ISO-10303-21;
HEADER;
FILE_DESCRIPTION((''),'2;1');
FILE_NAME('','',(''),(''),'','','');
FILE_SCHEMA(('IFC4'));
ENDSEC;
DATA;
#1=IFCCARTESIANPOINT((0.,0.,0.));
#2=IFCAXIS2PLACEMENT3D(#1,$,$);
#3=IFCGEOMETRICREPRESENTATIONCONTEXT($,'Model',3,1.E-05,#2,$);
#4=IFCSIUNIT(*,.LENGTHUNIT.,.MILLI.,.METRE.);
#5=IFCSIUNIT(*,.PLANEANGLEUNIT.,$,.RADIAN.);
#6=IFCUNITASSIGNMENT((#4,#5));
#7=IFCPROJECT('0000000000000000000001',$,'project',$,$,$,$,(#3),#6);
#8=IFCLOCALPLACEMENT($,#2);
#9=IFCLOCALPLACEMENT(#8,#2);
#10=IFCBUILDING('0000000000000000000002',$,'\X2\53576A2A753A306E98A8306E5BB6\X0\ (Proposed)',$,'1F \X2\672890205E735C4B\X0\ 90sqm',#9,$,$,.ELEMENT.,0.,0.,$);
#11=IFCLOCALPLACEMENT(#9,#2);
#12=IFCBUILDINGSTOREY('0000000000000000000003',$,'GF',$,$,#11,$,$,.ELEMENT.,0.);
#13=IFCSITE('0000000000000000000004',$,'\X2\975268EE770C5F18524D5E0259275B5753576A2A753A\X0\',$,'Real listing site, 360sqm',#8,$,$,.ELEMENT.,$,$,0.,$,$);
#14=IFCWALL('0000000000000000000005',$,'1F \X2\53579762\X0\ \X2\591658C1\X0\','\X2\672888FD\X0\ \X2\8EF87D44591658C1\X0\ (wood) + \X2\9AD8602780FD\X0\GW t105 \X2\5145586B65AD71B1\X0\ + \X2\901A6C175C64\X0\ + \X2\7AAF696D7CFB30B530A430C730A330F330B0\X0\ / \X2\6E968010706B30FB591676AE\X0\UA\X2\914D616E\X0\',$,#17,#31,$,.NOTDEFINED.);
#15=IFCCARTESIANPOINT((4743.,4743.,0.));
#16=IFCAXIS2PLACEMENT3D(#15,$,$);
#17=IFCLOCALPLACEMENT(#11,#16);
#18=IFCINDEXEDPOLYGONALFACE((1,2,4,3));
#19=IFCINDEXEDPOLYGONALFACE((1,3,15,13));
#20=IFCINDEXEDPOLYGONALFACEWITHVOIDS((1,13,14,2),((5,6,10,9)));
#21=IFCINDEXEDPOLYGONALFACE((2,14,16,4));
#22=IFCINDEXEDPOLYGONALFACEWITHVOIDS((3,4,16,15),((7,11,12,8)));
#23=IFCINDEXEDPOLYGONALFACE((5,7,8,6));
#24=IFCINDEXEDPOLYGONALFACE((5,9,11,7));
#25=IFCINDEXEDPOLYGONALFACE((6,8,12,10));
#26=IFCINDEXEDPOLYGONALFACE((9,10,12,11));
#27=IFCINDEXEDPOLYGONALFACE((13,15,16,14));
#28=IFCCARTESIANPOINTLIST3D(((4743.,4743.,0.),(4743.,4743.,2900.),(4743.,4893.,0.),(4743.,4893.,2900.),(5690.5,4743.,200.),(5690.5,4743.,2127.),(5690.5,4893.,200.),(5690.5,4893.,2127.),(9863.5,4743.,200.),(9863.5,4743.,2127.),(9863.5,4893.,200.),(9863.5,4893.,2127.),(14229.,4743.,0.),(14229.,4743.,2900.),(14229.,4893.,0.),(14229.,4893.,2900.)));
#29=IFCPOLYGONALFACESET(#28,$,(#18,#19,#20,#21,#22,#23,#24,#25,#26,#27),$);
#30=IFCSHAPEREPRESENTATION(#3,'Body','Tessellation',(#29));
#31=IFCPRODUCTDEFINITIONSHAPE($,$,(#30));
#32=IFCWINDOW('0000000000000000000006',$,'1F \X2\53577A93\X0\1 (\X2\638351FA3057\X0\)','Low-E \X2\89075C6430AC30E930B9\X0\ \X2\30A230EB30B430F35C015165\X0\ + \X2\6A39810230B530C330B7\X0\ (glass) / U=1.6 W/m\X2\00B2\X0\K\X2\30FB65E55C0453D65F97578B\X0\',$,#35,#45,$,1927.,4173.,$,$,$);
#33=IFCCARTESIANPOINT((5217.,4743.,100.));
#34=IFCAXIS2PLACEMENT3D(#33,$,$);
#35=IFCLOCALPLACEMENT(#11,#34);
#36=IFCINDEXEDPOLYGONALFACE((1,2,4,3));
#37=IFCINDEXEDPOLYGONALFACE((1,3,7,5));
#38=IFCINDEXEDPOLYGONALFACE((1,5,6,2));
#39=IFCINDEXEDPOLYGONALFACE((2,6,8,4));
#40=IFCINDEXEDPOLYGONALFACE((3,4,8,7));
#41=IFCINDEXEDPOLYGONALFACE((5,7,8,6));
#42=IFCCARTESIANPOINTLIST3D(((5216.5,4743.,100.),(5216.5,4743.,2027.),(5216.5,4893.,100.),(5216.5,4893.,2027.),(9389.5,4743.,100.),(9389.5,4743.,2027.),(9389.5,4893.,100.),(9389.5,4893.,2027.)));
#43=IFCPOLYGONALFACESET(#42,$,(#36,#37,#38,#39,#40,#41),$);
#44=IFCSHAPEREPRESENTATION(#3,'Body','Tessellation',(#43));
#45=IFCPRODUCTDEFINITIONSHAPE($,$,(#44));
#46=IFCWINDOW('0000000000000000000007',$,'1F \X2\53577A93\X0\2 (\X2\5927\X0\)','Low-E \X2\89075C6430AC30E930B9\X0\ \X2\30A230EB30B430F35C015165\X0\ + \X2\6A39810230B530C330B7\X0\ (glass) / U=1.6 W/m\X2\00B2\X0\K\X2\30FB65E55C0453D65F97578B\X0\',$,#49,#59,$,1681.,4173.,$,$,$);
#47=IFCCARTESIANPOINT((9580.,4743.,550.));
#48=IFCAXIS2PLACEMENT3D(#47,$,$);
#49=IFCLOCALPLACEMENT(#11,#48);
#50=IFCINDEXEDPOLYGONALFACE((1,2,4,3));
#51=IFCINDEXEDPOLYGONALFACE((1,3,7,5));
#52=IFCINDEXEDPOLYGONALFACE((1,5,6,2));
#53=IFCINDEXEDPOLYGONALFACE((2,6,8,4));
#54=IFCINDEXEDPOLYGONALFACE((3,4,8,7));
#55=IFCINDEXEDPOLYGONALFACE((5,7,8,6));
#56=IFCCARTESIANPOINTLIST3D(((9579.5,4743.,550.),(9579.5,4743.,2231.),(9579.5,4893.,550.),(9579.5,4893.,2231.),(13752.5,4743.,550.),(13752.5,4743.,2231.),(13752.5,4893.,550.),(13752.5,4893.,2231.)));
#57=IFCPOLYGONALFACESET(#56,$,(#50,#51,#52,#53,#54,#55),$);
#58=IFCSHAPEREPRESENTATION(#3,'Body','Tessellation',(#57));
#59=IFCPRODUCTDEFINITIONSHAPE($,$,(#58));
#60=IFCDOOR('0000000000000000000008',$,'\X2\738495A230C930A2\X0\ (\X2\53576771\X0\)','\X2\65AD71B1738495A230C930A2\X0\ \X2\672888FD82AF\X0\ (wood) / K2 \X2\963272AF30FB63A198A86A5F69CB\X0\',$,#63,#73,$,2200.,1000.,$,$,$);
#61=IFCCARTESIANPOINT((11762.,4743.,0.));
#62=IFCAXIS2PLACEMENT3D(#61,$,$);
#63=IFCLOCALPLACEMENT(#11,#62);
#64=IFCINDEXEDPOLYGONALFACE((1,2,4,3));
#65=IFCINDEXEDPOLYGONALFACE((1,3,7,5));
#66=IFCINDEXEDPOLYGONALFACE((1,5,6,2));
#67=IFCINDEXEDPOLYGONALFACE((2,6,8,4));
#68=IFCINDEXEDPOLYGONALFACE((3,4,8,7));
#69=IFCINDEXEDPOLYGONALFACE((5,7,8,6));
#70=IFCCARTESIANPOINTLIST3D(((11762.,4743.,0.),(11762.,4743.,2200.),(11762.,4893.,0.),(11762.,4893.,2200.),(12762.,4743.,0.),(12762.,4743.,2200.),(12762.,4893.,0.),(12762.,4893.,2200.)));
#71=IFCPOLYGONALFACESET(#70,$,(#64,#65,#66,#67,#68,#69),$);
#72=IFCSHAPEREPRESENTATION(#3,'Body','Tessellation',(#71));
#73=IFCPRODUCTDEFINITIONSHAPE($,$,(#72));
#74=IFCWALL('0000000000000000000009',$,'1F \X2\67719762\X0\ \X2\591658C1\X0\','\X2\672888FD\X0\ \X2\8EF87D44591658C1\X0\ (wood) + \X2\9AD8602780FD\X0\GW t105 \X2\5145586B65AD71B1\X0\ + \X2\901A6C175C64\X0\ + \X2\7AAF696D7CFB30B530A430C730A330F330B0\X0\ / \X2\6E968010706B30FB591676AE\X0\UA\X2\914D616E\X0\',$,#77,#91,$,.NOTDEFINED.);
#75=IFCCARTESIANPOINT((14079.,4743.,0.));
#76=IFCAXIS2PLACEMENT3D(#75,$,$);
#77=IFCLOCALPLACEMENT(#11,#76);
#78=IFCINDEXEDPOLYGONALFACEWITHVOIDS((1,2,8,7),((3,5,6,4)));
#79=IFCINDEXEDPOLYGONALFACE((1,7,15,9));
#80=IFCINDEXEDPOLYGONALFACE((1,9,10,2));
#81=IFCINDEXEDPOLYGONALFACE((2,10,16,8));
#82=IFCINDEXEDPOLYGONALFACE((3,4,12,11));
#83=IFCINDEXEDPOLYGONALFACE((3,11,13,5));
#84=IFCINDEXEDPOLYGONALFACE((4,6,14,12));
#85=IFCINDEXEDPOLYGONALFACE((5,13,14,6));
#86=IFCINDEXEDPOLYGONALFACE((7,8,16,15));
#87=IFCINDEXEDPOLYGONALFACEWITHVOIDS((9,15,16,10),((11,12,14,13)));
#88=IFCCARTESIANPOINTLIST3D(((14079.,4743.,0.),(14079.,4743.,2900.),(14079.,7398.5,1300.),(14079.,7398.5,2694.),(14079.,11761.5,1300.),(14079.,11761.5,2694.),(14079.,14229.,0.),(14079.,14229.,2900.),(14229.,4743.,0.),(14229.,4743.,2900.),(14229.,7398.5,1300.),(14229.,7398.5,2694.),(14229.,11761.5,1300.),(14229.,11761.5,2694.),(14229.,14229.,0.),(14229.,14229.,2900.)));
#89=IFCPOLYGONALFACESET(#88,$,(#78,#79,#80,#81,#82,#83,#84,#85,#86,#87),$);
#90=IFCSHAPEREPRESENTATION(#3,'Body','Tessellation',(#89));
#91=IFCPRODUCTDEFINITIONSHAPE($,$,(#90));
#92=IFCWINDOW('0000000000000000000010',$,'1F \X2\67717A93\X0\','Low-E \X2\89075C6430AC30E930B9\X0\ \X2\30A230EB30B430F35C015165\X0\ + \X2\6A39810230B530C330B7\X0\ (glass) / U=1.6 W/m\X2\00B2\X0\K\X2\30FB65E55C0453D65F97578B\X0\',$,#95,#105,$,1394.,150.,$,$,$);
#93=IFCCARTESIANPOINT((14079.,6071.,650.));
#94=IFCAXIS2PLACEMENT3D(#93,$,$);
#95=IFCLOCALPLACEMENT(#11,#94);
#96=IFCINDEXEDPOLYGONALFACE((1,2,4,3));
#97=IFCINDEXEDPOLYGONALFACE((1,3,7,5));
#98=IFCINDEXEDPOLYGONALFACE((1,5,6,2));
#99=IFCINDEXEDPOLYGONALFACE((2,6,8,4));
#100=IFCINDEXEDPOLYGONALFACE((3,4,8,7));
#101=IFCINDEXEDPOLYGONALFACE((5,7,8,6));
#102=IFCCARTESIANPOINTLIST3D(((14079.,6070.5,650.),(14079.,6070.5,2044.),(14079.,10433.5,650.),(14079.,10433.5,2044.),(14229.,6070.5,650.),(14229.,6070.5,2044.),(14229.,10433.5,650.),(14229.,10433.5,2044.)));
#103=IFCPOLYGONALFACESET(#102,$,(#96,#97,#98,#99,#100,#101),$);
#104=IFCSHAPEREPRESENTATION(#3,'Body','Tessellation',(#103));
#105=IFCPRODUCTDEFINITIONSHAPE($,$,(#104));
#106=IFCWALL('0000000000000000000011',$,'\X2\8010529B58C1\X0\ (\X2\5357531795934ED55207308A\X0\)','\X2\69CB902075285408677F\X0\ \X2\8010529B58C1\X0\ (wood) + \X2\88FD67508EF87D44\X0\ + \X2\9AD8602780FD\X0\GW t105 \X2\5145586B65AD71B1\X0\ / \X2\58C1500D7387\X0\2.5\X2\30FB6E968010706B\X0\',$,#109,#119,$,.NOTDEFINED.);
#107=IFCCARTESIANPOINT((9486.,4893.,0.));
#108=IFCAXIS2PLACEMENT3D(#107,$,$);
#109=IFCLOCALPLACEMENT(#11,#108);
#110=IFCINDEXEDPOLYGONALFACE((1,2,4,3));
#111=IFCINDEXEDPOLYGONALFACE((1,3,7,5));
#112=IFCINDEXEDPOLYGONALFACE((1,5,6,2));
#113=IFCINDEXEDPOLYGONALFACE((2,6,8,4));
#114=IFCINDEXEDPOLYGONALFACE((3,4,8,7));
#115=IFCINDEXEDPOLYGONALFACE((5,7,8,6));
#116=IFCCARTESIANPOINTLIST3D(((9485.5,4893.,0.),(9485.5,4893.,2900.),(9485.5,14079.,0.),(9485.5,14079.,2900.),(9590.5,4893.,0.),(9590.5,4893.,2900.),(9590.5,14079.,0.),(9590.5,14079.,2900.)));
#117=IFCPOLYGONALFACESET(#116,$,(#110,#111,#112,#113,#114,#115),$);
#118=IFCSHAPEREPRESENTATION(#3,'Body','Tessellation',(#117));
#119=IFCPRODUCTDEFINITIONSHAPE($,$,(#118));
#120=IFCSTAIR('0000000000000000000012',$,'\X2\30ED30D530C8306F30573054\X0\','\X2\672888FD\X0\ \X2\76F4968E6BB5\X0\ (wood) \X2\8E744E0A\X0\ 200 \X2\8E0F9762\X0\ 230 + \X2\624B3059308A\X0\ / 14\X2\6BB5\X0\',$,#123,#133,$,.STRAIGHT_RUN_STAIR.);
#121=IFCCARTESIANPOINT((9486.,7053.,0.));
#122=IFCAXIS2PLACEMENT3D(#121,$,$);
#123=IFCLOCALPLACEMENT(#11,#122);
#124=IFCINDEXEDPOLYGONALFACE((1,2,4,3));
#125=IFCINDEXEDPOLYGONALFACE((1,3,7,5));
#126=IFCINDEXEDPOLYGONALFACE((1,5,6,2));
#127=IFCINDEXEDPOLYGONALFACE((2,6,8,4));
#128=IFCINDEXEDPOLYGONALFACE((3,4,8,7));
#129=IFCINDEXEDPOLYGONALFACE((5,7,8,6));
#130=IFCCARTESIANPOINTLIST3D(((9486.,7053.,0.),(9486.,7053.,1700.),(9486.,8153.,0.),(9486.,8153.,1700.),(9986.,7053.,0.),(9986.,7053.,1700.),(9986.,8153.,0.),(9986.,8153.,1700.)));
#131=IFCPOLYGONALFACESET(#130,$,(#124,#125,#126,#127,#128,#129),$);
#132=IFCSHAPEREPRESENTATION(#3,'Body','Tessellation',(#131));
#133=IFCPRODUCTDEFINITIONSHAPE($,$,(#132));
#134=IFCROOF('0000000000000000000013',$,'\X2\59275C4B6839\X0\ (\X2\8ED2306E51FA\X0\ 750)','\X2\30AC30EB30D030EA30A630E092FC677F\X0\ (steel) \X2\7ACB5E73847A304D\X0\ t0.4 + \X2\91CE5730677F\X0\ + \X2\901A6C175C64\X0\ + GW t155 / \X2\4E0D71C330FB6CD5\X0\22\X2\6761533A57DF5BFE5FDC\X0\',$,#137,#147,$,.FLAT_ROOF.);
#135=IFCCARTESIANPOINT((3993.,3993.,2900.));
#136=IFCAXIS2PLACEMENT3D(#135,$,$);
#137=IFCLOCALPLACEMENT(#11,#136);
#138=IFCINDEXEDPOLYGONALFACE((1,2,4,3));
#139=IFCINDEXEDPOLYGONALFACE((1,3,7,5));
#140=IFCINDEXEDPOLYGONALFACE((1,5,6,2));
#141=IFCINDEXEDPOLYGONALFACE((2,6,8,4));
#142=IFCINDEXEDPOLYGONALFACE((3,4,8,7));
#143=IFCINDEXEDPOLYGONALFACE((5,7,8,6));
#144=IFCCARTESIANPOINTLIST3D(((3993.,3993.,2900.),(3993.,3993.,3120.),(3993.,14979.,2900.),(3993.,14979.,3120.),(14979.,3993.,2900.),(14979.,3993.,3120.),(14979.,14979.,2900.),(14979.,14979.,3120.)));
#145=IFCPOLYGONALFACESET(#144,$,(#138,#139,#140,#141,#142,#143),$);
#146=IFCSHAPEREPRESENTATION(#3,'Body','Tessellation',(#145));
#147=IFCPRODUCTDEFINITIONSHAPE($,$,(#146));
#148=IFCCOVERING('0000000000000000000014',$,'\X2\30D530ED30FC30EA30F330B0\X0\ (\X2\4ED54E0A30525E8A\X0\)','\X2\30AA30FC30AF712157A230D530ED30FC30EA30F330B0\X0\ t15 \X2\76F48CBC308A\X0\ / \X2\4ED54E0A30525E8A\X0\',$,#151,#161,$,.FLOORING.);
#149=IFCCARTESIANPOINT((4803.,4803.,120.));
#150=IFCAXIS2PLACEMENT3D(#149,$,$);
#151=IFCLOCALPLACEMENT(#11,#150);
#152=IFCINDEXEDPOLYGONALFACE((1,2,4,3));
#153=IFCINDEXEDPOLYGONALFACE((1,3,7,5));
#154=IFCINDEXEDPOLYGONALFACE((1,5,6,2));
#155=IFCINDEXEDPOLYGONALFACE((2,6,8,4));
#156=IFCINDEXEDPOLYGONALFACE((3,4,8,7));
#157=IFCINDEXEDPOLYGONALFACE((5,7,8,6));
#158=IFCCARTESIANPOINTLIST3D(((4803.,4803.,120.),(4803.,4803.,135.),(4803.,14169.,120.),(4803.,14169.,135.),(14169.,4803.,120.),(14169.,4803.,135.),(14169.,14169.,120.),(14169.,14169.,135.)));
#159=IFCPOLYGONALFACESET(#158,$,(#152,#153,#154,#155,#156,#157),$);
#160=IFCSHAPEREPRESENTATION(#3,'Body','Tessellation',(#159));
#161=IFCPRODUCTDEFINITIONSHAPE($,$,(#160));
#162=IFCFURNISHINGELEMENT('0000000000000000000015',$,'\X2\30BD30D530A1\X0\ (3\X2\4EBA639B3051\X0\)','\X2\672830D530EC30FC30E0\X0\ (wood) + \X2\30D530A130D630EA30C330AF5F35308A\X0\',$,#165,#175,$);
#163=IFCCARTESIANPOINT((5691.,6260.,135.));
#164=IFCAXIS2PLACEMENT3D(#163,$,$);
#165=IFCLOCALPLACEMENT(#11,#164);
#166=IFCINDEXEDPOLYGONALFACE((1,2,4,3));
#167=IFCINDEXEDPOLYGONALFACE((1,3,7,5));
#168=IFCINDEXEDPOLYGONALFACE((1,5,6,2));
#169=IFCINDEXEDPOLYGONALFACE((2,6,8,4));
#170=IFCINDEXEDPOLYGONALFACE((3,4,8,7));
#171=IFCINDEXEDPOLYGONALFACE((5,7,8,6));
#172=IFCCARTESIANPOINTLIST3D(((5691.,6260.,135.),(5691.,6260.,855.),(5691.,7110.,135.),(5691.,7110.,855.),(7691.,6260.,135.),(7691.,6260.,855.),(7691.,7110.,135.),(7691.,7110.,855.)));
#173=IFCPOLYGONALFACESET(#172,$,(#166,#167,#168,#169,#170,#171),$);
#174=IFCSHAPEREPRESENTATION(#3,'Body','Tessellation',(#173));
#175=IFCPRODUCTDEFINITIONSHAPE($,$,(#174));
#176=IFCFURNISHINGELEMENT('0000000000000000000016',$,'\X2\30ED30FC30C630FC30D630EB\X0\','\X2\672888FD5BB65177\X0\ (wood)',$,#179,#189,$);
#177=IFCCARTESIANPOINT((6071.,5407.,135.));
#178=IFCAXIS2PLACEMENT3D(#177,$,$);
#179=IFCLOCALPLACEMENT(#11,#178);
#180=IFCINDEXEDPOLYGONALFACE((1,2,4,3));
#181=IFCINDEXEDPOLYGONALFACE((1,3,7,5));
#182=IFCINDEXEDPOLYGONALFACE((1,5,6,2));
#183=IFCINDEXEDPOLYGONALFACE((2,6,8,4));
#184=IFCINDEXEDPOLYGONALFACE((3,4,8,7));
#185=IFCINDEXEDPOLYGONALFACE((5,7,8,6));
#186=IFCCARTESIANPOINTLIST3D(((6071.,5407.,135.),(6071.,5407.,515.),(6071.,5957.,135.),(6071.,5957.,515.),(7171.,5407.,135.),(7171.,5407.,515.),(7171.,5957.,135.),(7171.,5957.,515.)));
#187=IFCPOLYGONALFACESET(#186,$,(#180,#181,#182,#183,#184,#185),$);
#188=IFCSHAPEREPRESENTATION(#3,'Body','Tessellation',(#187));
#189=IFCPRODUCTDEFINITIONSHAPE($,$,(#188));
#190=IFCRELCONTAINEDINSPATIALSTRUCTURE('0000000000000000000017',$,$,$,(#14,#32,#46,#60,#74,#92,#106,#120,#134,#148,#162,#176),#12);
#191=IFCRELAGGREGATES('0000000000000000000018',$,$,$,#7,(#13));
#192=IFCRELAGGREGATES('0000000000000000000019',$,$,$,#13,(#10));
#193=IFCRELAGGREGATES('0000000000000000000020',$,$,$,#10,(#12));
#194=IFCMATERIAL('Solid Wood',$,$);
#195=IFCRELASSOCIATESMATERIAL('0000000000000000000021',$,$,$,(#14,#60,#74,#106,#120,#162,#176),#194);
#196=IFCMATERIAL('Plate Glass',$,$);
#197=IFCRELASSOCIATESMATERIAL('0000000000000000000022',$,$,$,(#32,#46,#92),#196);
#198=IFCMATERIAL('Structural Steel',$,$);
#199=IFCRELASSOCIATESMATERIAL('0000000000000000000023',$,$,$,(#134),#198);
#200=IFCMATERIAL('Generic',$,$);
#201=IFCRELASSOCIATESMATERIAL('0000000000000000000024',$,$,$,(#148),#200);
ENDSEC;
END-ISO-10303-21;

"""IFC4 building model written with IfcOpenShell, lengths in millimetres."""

from ifc_helpers import new_model, si_unit, frame, frame_2d, origin, place, context, project, spatial, rectangle, extrude, material, element, fill, save


model = new_model("IFC4")

# Units and contexts
model_context = context("Model", 3, precision=1e-05, world=origin())
ifc_project = project(units=[si_unit("LENGTHUNIT", "METRE", prefix="MILLI"), si_unit("PLANEANGLEUNIT", "RADIAN")], contexts=[model_context])

# Site, building, storey
site_placement = place(None, origin())
site = spatial("IfcSite", under=ifc_project, at=site_placement, Name="青森県弘前市大字南横町", ObjectType="Real listing site, 360sqm", CompositionType="ELEMENT", RefElevation=0.0)
building_placement = place(site_placement, origin())
building = spatial("IfcBuilding", under=site, at=building_placement, Name="南横町の風の家 (Proposed)", ObjectType="1F 木造平屋 90sqm", CompositionType="ELEMENT", ElevationOfRefHeight=0.0, ElevationOfTerrain=0.0)
storey_placement = place(building_placement, origin())
storey = spatial("IfcBuildingStorey", under=building, at=storey_placement, Name="GF", CompositionType="ELEMENT", Elevation=0.0)

# Shared definitions
ifc_material_1 = material(Name="Solid Wood")

# Wall, openings, windows, door
wall_1_placement = place(storey_placement, frame((4743.0, 4743.0, 0.0)))
wall_1 = element("IfcWall", 1, at=wall_1_placement, inside=storey, material=ifc_material_1, Name="1F 南面 外壁", Description="木製 軸組外壁 (wood) + 高性能GW t105 充填断熱 + 通気層 + 窯業系サイディング / 準耐火・外皮UA配慮", PredefinedType="NOTDEFINED", context=model_context, shape_type="SweptSolid", body=[
    extrude(rectangle(XDim=9486.0, YDim=150.0, at=frame_2d((4743.0, 75.0))), frame((4743.0, 4743.0, 0.0)), (0.0, 0.0, 1.0), 2900.0),
])
opening_1_placement = place(storey_placement, frame((5217.0, 4743.0, 100.0)))
opening_1 = element("IfcOpeningElement", 2, at=opening_1_placement, cuts=wall_1, PredefinedType="NOTDEFINED", context=model_context, shape_type="SweptSolid", body=[
    extrude(rectangle(XDim=4173.0, YDim=150.0, at=frame_2d((2086.0, 75.0))), frame((5217.0, 4743.0, 100.0)), (0.0, 0.0, 1.0), 1927.0),
])
opening_2_placement = place(storey_placement, frame((9580.0, 4743.0, 550.0)))
opening_2 = element("IfcOpeningElement", 3, at=opening_2_placement, cuts=wall_1, PredefinedType="NOTDEFINED", context=model_context, shape_type="SweptSolid", body=[
    extrude(rectangle(XDim=4173.0, YDim=150.0, at=frame_2d((2086.0, 75.0))), frame((9580.0, 4743.0, 550.0)), (0.0, 0.0, 1.0), 1681.0),
])
opening_3_placement = place(storey_placement, frame((11762.0, 4743.0, 0.0)))
opening_3 = element("IfcOpeningElement", 4, at=opening_3_placement, cuts=wall_1, PredefinedType="NOTDEFINED", context=model_context, shape_type="SweptSolid", body=[
    extrude(rectangle(XDim=1000.0, YDim=150.0, at=frame_2d((500.0, 75.0))), frame((11762.0, 4743.0, 0.0)), (0.0, 0.0, 1.0), 2200.0),
])
ifc_material_2 = material(Name="Plate Glass")
window_1_placement = place(storey_placement, frame((5217.0, 4743.0, 100.0)))
window_1 = element("IfcWindow", 5, at=window_1_placement, inside=storey, material=ifc_material_2, Name="1F 南窓1 (掃出し)", Description="Low-E 複層ガラス アルゴン封入 + 樹脂サッシ (glass) / U=1.6 W/m²K・日射取得型", OverallHeight=1927.0, OverallWidth=4173.0, context=model_context, shape_type="SweptSolid", body=[
    extrude(rectangle(XDim=4173.0, YDim=150.0, at=frame_2d((2086.0, 75.0))), frame((5217.0, 4743.0, 100.0)), (0.0, 0.0, 1.0), 1927.0),
])
fill(opening_1, window_1)
window_2_placement = place(storey_placement, frame((9580.0, 4743.0, 550.0)))
window_2 = element("IfcWindow", 6, at=window_2_placement, inside=storey, material=ifc_material_2, Name="1F 南窓2 (大)", Description="Low-E 複層ガラス アルゴン封入 + 樹脂サッシ (glass) / U=1.6 W/m²K・日射取得型", OverallHeight=1681.0, OverallWidth=4173.0, context=model_context, shape_type="SweptSolid", body=[
    extrude(rectangle(XDim=4173.0, YDim=150.0, at=frame_2d((2086.0, 75.0))), frame((9580.0, 4743.0, 550.0)), (0.0, 0.0, 1.0), 1681.0),
])
fill(opening_2, window_2)
door_placement = place(storey_placement, frame((11762.0, 4743.0, 0.0)))
door = element("IfcDoor", 7, at=door_placement, inside=storey, material=ifc_material_1, Name="玄関ドア (南東)", Description="断熱玄関ドア 木製芯 (wood) / K2 防犯・採風機構", OverallHeight=2200.0, OverallWidth=1000.0, context=model_context, shape_type="SweptSolid", body=[
    extrude(rectangle(XDim=1000.0, YDim=150.0, at=frame_2d((500.0, 75.0))), frame((11762.0, 4743.0, 0.0)), (0.0, 0.0, 1.0), 2200.0),
])
fill(opening_3, door)

# Wall, opening, window
wall_2_placement = place(storey_placement, frame((14079.0, 4743.0, 0.0)))
wall_2 = element("IfcWall", 8, at=wall_2_placement, inside=storey, material=ifc_material_1, Name="1F 東面 外壁", Description="木製 軸組外壁 (wood) + 高性能GW t105 充填断熱 + 通気層 + 窯業系サイディング / 準耐火・外皮UA配慮", PredefinedType="NOTDEFINED", context=model_context, shape_type="SweptSolid", body=[
    extrude(rectangle(XDim=150.0, YDim=9486.0, at=frame_2d((75.0, 4743.0))), frame((14079.0, 4743.0, 0.0)), (0.0, 0.0, 1.0), 2900.0),
])
opening_4_placement = place(storey_placement, frame((14079.0, 6071.0, 650.0)))
opening_4 = element("IfcOpeningElement", 9, at=opening_4_placement, cuts=wall_2, PredefinedType="NOTDEFINED", context=model_context, shape_type="SweptSolid", body=[
    extrude(rectangle(XDim=150.0, YDim=4363.0, at=frame_2d((75.0, 2181.0))), frame((14079.0, 6071.0, 650.0)), (0.0, 0.0, 1.0), 1394.0),
])
window_3_placement = place(storey_placement, frame((14079.0, 6071.0, 650.0)))
window_3 = element("IfcWindow", 10, at=window_3_placement, inside=storey, material=ifc_material_2, Name="1F 東窓", Description="Low-E 複層ガラス アルゴン封入 + 樹脂サッシ (glass) / U=1.6 W/m²K・日射取得型", OverallHeight=1394.0, OverallWidth=150.0, context=model_context, shape_type="SweptSolid", body=[
    extrude(rectangle(XDim=150.0, YDim=4363.0, at=frame_2d((75.0, 2181.0))), frame((14079.0, 6071.0, 650.0)), (0.0, 0.0, 1.0), 1394.0),
])
fill(opening_4, window_3)

# Wall
wall_3_placement = place(storey_placement, frame((9486.0, 4893.0, 0.0)))
element("IfcWall", 11, at=wall_3_placement, inside=storey, material=ifc_material_1, Name="耐力壁 (南北間仕切り)", Description="構造用合板 耐力壁 (wood) + 製材軸組 + 高性能GW t105 充填断熱 / 壁倍率2.5・準耐火", PredefinedType="NOTDEFINED", context=model_context, shape_type="SweptSolid", body=[
    extrude(rectangle(XDim=105.0, YDim=9186.0, at=frame_2d((52.0, 4593.0))), frame((9486.0, 4893.0, 0.0)), (0.0, 0.0, 1.0), 2900.0),
])

# Stair
stair_placement = place(storey_placement, frame((9486.0, 7053.0, 0.0)))
element("IfcStair", 12, at=stair_placement, inside=storey, material=ifc_material_1, Name="ロフトはしご", Description="木製 直階段 (wood) 蹴上 200 踏面 230 + 手すり / 14段", PredefinedType="STRAIGHT_RUN_STAIR", context=model_context, shape_type="SweptSolid", body=[
    extrude(rectangle(XDim=500.0, YDim=1100.0, at=frame_2d((250.0, 550.0))), frame((9486.0, 7053.0, 0.0)), (0.0, 0.0, 1.0), 1700.0),
])

# Roof
ifc_material_3 = material(Name="Structural Steel")
roof_placement = place(storey_placement, frame((3993.0, 3993.0, 2900.0)))
element("IfcRoof", 13, at=roof_placement, inside=storey, material=ifc_material_3, Name="大屋根 (軒の出 750)", Description="ガルバリウム鋼板 (steel) 立平葺き t0.4 + 野地板 + 通気層 + GW t155 / 不燃・法22条区域対応", PredefinedType="FLAT_ROOF", context=model_context, shape_type="SweptSolid", body=[
    extrude(rectangle(XDim=10986.0, YDim=10986.0, at=frame_2d((5493.0, 5493.0))), frame((3993.0, 3993.0, 2900.0)), (0.0, 0.0, 1.0), 220.0),
])

# Covering
ifc_material_4 = material(Name="Generic")
covering_placement = place(storey_placement, frame((4803.0, 4803.0, 120.0)))
element("IfcCovering", 14, at=covering_placement, inside=storey, material=ifc_material_4, Name="フローリング (仕上げ床)", Description="オーク無垢フローリング t15 直貼り / 仕上げ床", PredefinedType="FLOORING", context=model_context, shape_type="SweptSolid", body=[
    extrude(rectangle(XDim=9366.0, YDim=9366.0, at=frame_2d((4683.0, 4683.0))), frame((4803.0, 4803.0, 120.0)), (0.0, 0.0, 1.0), 15.0),
])

# Furnishing elements
furnishing_1_placement = place(storey_placement, frame((5691.0, 6260.0, 135.0)))
element("IfcFurnishingElement", 15, at=furnishing_1_placement, inside=storey, material=ifc_material_1, Name="ソファ (3人掛け)", Description="木フレーム (wood) + ファブリック張り", context=model_context, shape_type="SweptSolid", body=[
    extrude(rectangle(XDim=2000.0, YDim=850.0, at=frame_2d((1000.0, 425.0))), frame((5691.0, 6260.0, 135.0)), (0.0, 0.0, 1.0), 720.0),
])
furnishing_2_placement = place(storey_placement, frame((6071.0, 5407.0, 135.0)))
element("IfcFurnishingElement", 16, at=furnishing_2_placement, inside=storey, material=ifc_material_1, Name="ローテーブル", Description="木製家具 (wood)", context=model_context, shape_type="SweptSolid", body=[
    extrude(rectangle(XDim=1100.0, YDim=550.0, at=frame_2d((550.0, 275.0))), frame((6071.0, 5407.0, 135.0)), (0.0, 0.0, 1.0), 380.0),
])

save(model, "model.ifc")
